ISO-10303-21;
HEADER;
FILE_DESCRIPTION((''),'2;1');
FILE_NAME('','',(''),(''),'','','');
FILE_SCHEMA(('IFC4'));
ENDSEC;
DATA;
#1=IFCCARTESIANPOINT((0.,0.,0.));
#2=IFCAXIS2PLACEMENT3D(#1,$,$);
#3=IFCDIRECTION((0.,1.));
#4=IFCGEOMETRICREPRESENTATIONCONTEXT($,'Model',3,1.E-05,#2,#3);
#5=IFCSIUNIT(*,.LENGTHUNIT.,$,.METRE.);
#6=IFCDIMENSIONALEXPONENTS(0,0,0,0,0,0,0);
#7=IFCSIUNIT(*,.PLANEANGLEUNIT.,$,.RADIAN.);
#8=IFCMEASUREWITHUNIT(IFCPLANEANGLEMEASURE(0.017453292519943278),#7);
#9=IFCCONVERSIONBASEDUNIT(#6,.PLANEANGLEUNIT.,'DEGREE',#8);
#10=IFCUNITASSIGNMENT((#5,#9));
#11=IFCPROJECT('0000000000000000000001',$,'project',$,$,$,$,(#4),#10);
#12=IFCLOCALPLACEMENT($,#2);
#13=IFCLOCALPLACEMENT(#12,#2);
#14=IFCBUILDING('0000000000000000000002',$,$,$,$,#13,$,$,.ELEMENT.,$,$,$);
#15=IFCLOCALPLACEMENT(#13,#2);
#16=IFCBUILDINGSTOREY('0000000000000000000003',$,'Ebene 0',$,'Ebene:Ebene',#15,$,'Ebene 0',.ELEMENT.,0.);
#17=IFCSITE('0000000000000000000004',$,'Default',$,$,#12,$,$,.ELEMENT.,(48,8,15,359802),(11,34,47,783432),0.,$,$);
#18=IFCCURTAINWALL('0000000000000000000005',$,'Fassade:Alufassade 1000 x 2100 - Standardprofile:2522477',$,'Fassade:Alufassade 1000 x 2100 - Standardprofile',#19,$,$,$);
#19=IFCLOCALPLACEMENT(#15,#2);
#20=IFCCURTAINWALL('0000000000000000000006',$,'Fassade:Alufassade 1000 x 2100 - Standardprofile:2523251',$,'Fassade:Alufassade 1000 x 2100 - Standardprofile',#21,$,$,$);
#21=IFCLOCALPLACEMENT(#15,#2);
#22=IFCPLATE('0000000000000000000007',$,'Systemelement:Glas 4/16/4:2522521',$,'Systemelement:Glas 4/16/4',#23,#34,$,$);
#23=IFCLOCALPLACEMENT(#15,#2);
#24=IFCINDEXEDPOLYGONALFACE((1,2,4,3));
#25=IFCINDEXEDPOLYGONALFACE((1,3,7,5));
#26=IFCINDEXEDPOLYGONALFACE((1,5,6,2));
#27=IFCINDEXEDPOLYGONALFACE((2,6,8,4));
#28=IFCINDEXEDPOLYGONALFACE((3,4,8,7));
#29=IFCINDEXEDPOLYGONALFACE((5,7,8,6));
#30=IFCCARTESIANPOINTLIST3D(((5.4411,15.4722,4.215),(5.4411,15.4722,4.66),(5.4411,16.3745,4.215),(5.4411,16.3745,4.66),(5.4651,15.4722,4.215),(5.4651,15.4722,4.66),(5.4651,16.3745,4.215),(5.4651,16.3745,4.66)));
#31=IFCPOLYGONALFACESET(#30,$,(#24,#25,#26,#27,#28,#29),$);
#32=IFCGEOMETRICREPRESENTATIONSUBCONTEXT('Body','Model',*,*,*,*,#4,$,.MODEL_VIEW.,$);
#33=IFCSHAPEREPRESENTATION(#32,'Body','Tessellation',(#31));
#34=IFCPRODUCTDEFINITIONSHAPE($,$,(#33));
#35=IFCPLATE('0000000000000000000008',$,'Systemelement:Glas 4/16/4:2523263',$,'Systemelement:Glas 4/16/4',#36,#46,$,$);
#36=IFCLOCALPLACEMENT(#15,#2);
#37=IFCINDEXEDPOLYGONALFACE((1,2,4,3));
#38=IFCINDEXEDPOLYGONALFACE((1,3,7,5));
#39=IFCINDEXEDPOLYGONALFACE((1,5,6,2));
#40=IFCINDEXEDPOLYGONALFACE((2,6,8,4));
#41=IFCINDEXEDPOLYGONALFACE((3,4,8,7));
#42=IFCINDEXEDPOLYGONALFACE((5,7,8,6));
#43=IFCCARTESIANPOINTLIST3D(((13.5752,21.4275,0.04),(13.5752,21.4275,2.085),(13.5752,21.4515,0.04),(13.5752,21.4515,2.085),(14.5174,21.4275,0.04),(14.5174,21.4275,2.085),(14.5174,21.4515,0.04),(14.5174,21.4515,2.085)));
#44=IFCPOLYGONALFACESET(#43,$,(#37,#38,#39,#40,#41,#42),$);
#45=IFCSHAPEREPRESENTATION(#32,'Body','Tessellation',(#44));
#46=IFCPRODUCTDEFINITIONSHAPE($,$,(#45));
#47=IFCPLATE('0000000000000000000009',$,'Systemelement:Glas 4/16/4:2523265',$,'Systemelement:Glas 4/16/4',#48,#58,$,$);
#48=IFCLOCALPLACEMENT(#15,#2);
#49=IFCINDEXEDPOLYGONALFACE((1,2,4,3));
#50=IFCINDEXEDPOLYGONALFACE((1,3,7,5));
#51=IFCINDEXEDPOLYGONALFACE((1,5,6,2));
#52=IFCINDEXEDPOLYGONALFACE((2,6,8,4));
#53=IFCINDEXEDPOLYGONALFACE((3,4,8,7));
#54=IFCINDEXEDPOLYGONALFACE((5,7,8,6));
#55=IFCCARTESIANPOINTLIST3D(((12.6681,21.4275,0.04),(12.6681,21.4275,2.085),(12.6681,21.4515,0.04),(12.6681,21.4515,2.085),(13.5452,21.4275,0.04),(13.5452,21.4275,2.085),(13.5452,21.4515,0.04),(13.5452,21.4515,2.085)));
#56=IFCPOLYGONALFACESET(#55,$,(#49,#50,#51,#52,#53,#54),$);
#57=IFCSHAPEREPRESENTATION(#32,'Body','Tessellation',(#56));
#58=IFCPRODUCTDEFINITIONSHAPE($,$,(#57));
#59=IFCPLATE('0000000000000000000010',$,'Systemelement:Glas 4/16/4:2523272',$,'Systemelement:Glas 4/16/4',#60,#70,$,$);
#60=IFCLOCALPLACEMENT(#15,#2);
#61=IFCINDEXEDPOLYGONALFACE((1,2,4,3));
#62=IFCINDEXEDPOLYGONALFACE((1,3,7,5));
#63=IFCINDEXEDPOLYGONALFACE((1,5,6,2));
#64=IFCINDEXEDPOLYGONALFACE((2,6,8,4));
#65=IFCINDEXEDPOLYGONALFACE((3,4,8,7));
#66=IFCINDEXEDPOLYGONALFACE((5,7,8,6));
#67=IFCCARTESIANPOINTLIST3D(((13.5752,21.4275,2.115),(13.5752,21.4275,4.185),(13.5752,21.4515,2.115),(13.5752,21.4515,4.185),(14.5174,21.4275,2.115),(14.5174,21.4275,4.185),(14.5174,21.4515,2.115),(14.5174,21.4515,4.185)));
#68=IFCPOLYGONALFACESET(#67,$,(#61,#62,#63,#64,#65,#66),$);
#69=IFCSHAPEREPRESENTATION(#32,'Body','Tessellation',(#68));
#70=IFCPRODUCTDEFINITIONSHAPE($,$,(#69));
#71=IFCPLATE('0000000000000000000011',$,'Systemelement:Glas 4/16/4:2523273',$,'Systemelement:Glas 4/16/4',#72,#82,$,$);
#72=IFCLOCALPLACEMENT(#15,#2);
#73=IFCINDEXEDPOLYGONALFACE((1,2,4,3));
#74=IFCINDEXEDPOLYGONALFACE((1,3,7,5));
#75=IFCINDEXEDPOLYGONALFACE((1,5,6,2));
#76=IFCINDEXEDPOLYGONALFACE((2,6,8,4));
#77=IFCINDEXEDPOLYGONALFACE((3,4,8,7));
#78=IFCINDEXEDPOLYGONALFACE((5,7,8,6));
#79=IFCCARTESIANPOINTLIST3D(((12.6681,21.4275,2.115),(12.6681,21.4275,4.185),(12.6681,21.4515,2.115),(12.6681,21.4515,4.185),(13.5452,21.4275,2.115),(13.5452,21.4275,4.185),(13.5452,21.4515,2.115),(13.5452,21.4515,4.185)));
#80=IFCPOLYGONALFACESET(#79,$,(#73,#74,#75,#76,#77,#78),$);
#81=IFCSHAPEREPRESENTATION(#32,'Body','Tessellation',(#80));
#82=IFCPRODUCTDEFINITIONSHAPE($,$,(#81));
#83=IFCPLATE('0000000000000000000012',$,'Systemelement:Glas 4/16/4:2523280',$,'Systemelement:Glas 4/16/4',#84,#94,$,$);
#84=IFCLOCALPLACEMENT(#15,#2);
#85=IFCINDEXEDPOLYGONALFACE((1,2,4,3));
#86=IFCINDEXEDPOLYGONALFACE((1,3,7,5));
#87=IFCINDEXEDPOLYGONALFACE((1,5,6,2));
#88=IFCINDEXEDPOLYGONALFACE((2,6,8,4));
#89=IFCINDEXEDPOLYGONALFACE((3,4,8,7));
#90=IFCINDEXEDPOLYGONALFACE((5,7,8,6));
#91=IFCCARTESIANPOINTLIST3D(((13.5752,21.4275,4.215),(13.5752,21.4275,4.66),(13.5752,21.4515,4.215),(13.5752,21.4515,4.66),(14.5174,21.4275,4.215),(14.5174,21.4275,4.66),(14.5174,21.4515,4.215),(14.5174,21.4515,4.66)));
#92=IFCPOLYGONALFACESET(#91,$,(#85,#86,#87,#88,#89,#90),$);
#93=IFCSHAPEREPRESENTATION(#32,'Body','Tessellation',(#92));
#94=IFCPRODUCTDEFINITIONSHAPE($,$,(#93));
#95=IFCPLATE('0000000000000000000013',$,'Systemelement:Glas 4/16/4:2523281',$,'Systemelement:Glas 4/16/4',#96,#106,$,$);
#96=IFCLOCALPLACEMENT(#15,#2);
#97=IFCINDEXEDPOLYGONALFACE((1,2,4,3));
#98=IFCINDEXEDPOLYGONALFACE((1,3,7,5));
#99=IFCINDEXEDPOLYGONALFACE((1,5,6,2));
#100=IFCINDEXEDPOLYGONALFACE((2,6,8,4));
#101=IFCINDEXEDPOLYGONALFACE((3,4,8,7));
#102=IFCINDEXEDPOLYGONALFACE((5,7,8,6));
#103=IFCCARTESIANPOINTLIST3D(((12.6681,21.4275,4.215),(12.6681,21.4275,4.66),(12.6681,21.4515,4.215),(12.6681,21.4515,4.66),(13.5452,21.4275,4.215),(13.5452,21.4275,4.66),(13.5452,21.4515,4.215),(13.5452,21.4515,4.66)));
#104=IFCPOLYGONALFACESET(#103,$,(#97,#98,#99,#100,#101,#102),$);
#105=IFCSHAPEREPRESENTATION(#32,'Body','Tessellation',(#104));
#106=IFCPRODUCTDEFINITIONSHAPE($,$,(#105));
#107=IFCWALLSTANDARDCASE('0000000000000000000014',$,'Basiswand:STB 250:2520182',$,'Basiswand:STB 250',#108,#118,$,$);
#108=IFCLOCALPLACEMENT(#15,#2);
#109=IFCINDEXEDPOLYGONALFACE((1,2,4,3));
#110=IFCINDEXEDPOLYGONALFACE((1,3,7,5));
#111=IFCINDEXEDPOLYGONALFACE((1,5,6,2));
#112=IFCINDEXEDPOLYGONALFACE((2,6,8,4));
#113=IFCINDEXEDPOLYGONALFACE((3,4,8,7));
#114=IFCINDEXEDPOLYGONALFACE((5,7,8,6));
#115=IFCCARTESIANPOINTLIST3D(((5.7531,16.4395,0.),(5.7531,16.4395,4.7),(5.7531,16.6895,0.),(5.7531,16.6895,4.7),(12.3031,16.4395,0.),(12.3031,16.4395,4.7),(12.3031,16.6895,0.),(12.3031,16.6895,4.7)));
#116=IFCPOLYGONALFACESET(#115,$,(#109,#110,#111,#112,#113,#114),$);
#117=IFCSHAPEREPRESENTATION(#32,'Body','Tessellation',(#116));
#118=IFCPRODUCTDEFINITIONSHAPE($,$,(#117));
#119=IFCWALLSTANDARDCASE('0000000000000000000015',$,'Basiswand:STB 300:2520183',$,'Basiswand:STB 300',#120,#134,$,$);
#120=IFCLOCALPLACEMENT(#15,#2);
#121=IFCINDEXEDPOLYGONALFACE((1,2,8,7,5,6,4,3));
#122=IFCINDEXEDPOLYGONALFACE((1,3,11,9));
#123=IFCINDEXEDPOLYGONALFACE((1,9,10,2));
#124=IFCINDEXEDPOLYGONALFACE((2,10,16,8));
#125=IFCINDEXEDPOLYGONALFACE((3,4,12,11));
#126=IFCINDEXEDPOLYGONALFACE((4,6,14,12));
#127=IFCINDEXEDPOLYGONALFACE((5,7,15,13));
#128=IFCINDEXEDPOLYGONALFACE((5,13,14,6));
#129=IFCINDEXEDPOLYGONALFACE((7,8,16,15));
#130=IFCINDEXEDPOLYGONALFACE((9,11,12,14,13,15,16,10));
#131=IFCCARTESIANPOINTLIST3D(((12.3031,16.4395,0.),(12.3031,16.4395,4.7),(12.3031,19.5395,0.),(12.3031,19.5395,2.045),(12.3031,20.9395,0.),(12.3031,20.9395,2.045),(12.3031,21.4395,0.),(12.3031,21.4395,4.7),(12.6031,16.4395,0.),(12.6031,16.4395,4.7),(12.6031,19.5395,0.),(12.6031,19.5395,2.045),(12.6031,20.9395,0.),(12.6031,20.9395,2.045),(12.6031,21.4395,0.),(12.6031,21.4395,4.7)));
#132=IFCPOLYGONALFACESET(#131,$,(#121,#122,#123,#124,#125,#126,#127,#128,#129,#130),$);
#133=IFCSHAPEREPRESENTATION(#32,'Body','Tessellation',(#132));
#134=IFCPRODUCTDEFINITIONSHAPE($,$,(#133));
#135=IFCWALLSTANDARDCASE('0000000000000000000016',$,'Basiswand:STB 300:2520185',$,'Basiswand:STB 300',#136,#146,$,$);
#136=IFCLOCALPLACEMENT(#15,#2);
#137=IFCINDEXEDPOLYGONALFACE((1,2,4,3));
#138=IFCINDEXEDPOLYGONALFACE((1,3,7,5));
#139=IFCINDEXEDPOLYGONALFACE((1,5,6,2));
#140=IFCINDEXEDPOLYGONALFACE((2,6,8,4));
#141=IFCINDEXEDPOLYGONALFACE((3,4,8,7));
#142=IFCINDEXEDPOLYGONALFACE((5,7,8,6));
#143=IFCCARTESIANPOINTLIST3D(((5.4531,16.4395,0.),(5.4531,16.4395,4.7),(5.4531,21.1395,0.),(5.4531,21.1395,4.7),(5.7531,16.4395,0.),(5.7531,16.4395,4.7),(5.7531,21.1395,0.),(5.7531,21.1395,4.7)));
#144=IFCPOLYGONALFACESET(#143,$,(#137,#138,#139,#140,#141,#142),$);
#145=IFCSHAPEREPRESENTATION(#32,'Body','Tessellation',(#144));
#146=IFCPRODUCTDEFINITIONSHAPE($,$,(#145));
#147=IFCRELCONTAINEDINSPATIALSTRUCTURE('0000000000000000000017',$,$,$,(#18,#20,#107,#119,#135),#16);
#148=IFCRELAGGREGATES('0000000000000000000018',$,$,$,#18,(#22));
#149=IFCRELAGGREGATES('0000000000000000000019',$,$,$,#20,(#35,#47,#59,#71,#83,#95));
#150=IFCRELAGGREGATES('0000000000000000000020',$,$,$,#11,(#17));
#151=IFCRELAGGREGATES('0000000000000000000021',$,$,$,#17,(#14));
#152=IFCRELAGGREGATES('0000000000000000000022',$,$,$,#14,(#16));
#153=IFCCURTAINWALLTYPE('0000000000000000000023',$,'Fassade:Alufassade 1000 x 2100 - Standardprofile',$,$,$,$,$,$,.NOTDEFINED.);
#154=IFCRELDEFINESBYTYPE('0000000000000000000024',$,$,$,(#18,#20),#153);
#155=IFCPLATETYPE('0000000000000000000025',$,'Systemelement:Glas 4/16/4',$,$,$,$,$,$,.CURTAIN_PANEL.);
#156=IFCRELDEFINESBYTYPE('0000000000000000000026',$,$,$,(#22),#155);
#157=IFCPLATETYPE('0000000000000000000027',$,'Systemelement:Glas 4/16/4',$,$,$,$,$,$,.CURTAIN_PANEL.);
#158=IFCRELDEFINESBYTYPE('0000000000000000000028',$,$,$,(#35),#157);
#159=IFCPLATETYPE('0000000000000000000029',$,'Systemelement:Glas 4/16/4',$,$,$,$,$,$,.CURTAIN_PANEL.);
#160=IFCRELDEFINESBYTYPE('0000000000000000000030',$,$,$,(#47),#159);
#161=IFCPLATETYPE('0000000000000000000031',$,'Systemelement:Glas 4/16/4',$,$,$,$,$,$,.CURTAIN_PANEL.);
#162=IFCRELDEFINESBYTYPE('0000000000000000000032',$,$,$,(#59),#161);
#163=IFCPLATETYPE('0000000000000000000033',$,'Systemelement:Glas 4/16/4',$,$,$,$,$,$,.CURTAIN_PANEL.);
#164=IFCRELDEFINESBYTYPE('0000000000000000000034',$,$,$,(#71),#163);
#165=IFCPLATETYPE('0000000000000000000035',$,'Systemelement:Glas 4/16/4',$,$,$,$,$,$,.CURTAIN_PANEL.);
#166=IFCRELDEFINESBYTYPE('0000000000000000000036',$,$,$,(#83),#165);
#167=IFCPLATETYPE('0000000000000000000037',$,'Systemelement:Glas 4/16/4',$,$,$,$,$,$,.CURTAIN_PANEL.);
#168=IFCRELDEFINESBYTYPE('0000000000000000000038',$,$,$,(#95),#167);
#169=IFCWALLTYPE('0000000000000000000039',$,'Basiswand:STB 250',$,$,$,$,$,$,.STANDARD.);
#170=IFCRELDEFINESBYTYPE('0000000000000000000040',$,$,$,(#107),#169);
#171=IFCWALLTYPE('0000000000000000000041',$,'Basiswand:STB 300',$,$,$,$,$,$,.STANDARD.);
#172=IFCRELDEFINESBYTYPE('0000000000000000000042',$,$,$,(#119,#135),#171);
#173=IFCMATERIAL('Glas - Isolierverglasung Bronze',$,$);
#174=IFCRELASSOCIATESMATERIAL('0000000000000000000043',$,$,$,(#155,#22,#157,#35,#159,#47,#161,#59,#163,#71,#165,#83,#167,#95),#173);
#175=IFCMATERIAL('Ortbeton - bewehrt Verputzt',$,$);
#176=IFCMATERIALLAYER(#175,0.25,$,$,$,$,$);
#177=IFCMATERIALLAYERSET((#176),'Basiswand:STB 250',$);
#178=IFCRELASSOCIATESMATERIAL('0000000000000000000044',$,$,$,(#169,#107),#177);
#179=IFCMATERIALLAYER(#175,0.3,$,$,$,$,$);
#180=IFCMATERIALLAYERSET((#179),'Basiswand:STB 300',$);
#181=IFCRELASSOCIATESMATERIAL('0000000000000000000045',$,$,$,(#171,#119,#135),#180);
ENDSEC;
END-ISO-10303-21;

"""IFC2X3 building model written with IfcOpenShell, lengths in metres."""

from ifc_helpers import new_model, entity, si_unit, converted_unit, direction, frame, frame_2d, origin, origin_2d_with_axis, place, context, subcontext, project, spatial, polyline, rectangle, extrude, clip, bounded_halfspace, source, transform, mapped, material, layer, layer_set, layer_usage, type_object, type_shapes, element, aggregate, save


model = new_model("IFC2X3")

# Units and contexts
model_context = context("Model", 3, precision=1e-05, world=origin(), true_north=direction((0.0, 1.0)))
body_context = subcontext(model_context, "Body", "Model", "MODEL_VIEW")
ifc_project = project(units=[si_unit("LENGTHUNIT", "METRE"), converted_unit("PLANEANGLEUNIT", "DEGREE", entity("IfcPlaneAngleMeasure", 0.017453292519943278), si_unit("PLANEANGLEUNIT", "RADIAN"), dimensions=[0, 0, 0, 0, 0, 0, 0])], contexts=[model_context])

# Site, building, storey
site_placement = place(None, origin())
site = spatial("IfcSite", under=ifc_project, at=site_placement, Name="Default", CompositionType="ELEMENT", RefLatitude=(48, 8, 15, 359802), RefLongitude=(11, 34, 47, 783432), RefElevation=0.0)
building_placement = place(site_placement, origin())
building = spatial("IfcBuilding", under=site, at=building_placement, CompositionType="ELEMENT")
storey_placement = place(building_placement, origin())
storey = spatial("IfcBuildingStorey", under=building, at=storey_placement, Name="Ebene 0", ObjectType="Ebene:Ebene", LongName="Ebene 0", CompositionType="ELEMENT", Elevation=0.0)

# Curtain wall
curtain_wall_type = type_object("IfcCurtainWallType", Name="Fassade:Alufassade 1000 x 2100 - Standardprofile", PredefinedType="NOTDEFINED")
curtain_wall_1_placement = place(storey_placement, origin())
curtain_wall_1 = element("IfcCurtainWall", 1, at=curtain_wall_1_placement, inside=storey, type_object=curtain_wall_type, Name="Fassade:Alufassade 1000 x 2100 - Standardprofile:2522477", ObjectType="Fassade:Alufassade 1000 x 2100 - Standardprofile")

# Curtain wall
curtain_wall_2_placement = place(storey_placement, origin())
curtain_wall_2 = element("IfcCurtainWall", 2, at=curtain_wall_2_placement, inside=storey, type_object=curtain_wall_type, Name="Fassade:Alufassade 1000 x 2100 - Standardprofile:2523251", ObjectType="Fassade:Alufassade 1000 x 2100 - Standardprofile")

# Plates
ifc_material_1 = material(Name="Glas - Isolierverglasung Bronze")
plate_type_1 = type_object("IfcPlateType", Name="Systemelement:Glas 4/16/4", PredefinedType="CURTAIN_PANEL", material=ifc_material_1)
shared_shape_1 = source(origin(), body_context, "Body", "SweptSolid", [
    extrude(rectangle(XDim=0.024, YDim=0.9023, at=origin_2d_with_axis()), frame((0.0, 0.0, 0.0), z_axis=(0.0, 0.0, 1.0), x_axis=(0.0, 1.0, 0.0)), (0.0, 0.0, 1.0), 0.445),
])
type_shapes(plate_type_1, [shared_shape_1])
plate_1_placement = place(curtain_wall_1_placement, frame((5.4531, 15.9233, 4.215), z_axis=(0.0, 0.0, 1.0), x_axis=(0.0, -1.0, 0.0)))
plate_1 = element("IfcPlate", 3, at=plate_1_placement, type_object=plate_type_1, material=ifc_material_1, Name="Systemelement:Glas 4/16/4:2522521", ObjectType="Systemelement:Glas 4/16/4", context=body_context, shape_type="MappedRepresentation", body=[
    mapped(shared_shape_1, transform((0.0, 0.0, 0.0), scale=1.0)),
])
aggregate(curtain_wall_1, [plate_1])
plate_type_2 = type_object("IfcPlateType", Name="Systemelement:Glas 4/16/4", PredefinedType="CURTAIN_PANEL", material=ifc_material_1)
shared_shape_2 = source(origin(), body_context, "Body", "SweptSolid", [
    extrude(rectangle(XDim=0.024, YDim=0.9421, at=origin_2d_with_axis()), frame((0.0, 0.0, 0.0), z_axis=(0.0, 0.0, 1.0), x_axis=(0.0, 1.0, 0.0)), (0.0, 0.0, 1.0), 2.045),
])
type_shapes(plate_type_2, [shared_shape_2])
plate_2_placement = place(curtain_wall_2_placement, frame((14.0463, 21.4395, 0.04), z_axis=(0.0, 0.0, 1.0), x_axis=(-1.0, 0.0, 0.0)))
plate_2 = element("IfcPlate", 4, at=plate_2_placement, type_object=plate_type_2, material=ifc_material_1, Name="Systemelement:Glas 4/16/4:2523263", ObjectType="Systemelement:Glas 4/16/4", context=body_context, shape_type="MappedRepresentation", body=[
    mapped(shared_shape_2, transform((0.0, 0.0, 0.0), scale=1.0)),
])
plate_type_3 = type_object("IfcPlateType", Name="Systemelement:Glas 4/16/4", PredefinedType="CURTAIN_PANEL", material=ifc_material_1)
shared_shape_3 = source(origin(), body_context, "Body", "SweptSolid", [
    extrude(rectangle(XDim=0.024, YDim=0.8771, at=origin_2d_with_axis()), frame((0.0, 0.0, 0.0), z_axis=(0.0, 0.0, 1.0), x_axis=(0.0, 1.0, 0.0)), (0.0, 0.0, 1.0), 2.045),
])
type_shapes(plate_type_3, [shared_shape_3])
plate_3_placement = place(curtain_wall_2_placement, frame((13.1067, 21.4395, 0.04), z_axis=(0.0, 0.0, 1.0), x_axis=(-1.0, 0.0, 0.0)))
plate_3 = element("IfcPlate", 5, at=plate_3_placement, type_object=plate_type_3, material=ifc_material_1, Name="Systemelement:Glas 4/16/4:2523265", ObjectType="Systemelement:Glas 4/16/4", context=body_context, shape_type="MappedRepresentation", body=[
    mapped(shared_shape_3, transform((0.0, 0.0, 0.0), scale=1.0)),
])
plate_type_4 = type_object("IfcPlateType", Name="Systemelement:Glas 4/16/4", PredefinedType="CURTAIN_PANEL", material=ifc_material_1)
shared_shape_4 = source(origin(), body_context, "Body", "SweptSolid", [
    extrude(rectangle(XDim=0.024, YDim=0.9421, at=origin_2d_with_axis()), frame((0.0, 0.0, 0.0), z_axis=(0.0, 0.0, 1.0), x_axis=(0.0, 1.0, 0.0)), (0.0, 0.0, 1.0), 2.07),
])
type_shapes(plate_type_4, [shared_shape_4])
plate_4_placement = place(curtain_wall_2_placement, frame((14.0463, 21.4395, 2.115), z_axis=(0.0, 0.0, 1.0), x_axis=(-1.0, 0.0, 0.0)))
plate_4 = element("IfcPlate", 6, at=plate_4_placement, type_object=plate_type_4, material=ifc_material_1, Name="Systemelement:Glas 4/16/4:2523272", ObjectType="Systemelement:Glas 4/16/4", context=body_context, shape_type="MappedRepresentation", body=[
    mapped(shared_shape_4, transform((0.0, 0.0, 0.0), scale=1.0)),
])
plate_type_5 = type_object("IfcPlateType", Name="Systemelement:Glas 4/16/4", PredefinedType="CURTAIN_PANEL", material=ifc_material_1)
shared_shape_5 = source(origin(), body_context, "Body", "SweptSolid", [
    extrude(rectangle(XDim=0.024, YDim=0.8771, at=origin_2d_with_axis()), frame((0.0, 0.0, 0.0), z_axis=(0.0, 0.0, 1.0), x_axis=(0.0, 1.0, 0.0)), (0.0, 0.0, 1.0), 2.07),
])
type_shapes(plate_type_5, [shared_shape_5])
plate_5_placement = place(curtain_wall_2_placement, frame((13.1067, 21.4395, 2.115), z_axis=(0.0, 0.0, 1.0), x_axis=(-1.0, 0.0, 0.0)))
plate_5 = element("IfcPlate", 7, at=plate_5_placement, type_object=plate_type_5, material=ifc_material_1, Name="Systemelement:Glas 4/16/4:2523273", ObjectType="Systemelement:Glas 4/16/4", context=body_context, shape_type="MappedRepresentation", body=[
    mapped(shared_shape_5, transform((0.0, 0.0, 0.0), scale=1.0)),
])
plate_type_6 = type_object("IfcPlateType", Name="Systemelement:Glas 4/16/4", PredefinedType="CURTAIN_PANEL", material=ifc_material_1)
shared_shape_6 = source(origin(), body_context, "Body", "SweptSolid", [
    extrude(rectangle(XDim=0.024, YDim=0.9421, at=origin_2d_with_axis()), frame((0.0, 0.0, 0.0), z_axis=(0.0, 0.0, 1.0), x_axis=(0.0, 1.0, 0.0)), (0.0, 0.0, 1.0), 0.445),
])
type_shapes(plate_type_6, [shared_shape_6])
plate_6_placement = place(curtain_wall_2_placement, frame((14.0463, 21.4395, 4.215), z_axis=(0.0, 0.0, 1.0), x_axis=(-1.0, 0.0, 0.0)))
plate_6 = element("IfcPlate", 8, at=plate_6_placement, type_object=plate_type_6, material=ifc_material_1, Name="Systemelement:Glas 4/16/4:2523280", ObjectType="Systemelement:Glas 4/16/4", context=body_context, shape_type="MappedRepresentation", body=[
    mapped(shared_shape_6, transform((0.0, 0.0, 0.0), scale=1.0)),
])
plate_type_7 = type_object("IfcPlateType", Name="Systemelement:Glas 4/16/4", PredefinedType="CURTAIN_PANEL", material=ifc_material_1)
shared_shape_7 = source(origin(), body_context, "Body", "SweptSolid", [
    extrude(rectangle(XDim=0.024, YDim=0.8771, at=origin_2d_with_axis()), frame((0.0, 0.0, 0.0), z_axis=(0.0, 0.0, 1.0), x_axis=(0.0, 1.0, 0.0)), (0.0, 0.0, 1.0), 0.445),
])
type_shapes(plate_type_7, [shared_shape_7])
plate_7_placement = place(curtain_wall_2_placement, frame((13.1067, 21.4395, 4.215), z_axis=(0.0, 0.0, 1.0), x_axis=(-1.0, 0.0, 0.0)))
plate_7 = element("IfcPlate", 9, at=plate_7_placement, type_object=plate_type_7, material=ifc_material_1, Name="Systemelement:Glas 4/16/4:2523281", ObjectType="Systemelement:Glas 4/16/4", context=body_context, shape_type="MappedRepresentation", body=[
    mapped(shared_shape_7, transform((0.0, 0.0, 0.0), scale=1.0)),
])
aggregate(curtain_wall_2, [plate_2, plate_3, plate_4, plate_5, plate_6, plate_7])

# Wall
ifc_material_2 = material(Name="Ortbeton - bewehrt Verputzt")
ifc_layer_1 = layer(ifc_material_2, 0.25)
ifc_layer_set_1 = layer_set([ifc_layer_1], Name="Basiswand:STB 250")
ifc_layer_usage_1 = layer_usage(ifc_layer_set_1, "AXIS2", "NEGATIVE", 0.125)
wall_type_1 = type_object("IfcWallType", Name="Basiswand:STB 250", PredefinedType="STANDARD", material=ifc_layer_set_1)
wall_1_placement = place(storey_placement, frame((12.3031, 16.5645, 0.0), z_axis=(0.0, 0.0, 1.0), x_axis=(-1.0, 0.0, 0.0)))
element("IfcWallStandardCase", 10, at=wall_1_placement, inside=storey, type_object=wall_type_1, material=ifc_layer_usage_1, Name="Basiswand:STB 250:2520182", ObjectType="Basiswand:STB 250", context=body_context, shape_type="Clipping", body=[
    clip(extrude(rectangle(XDim=6.55, YDim=0.25, at=frame_2d((3.275, 0.0), x_axis=(-1.0, 0.0))), origin(), (0.0, 0.0, 1.0), 4.7), bounded_halfspace(frame((0.0, -0.125, 4.7), z_axis=(0.0, 0.0, -1.0), x_axis=(0.0, 1.0, 0.0)), True, frame((0.0, -0.125, 4.7)), polyline([(0.0, 0.0), (6.55, 0.0), (6.55, 0.25), (3.6, 0.25), (3.3, 0.25), (0.0, 0.25), (0.0, 0.0)]))),
])

# Wall, opening
ifc_layer_2 = layer(ifc_material_2, 0.3)
ifc_layer_set_2 = layer_set([ifc_layer_2], Name="Basiswand:STB 300")
ifc_layer_usage_2 = layer_usage(ifc_layer_set_2, "AXIS2", "NEGATIVE", 0.15)
wall_type_2 = type_object("IfcWallType", Name="Basiswand:STB 300", PredefinedType="STANDARD", material=ifc_layer_set_2)
wall_2_placement = place(storey_placement, frame((12.4531, 21.4395, 0.0), z_axis=(0.0, 0.0, 1.0), x_axis=(0.0, -1.0, 0.0)))
wall_2 = element("IfcWallStandardCase", 11, at=wall_2_placement, inside=storey, type_object=wall_type_2, material=ifc_layer_usage_2, Name="Basiswand:STB 300:2520183", ObjectType="Basiswand:STB 300", context=body_context, shape_type="Clipping", body=[
    clip(extrude(rectangle(XDim=5.0, YDim=0.3, at=frame_2d((2.5, 0.0), x_axis=(-1.0, 0.0))), origin(), (0.0, 0.0, 1.0), 4.7), bounded_halfspace(frame((0.0, -0.15, 4.7), z_axis=(0.0, 0.0, -1.0), x_axis=(1.0, 0.0, 0.0)), True, frame((0.0, -0.15, 4.7)), polyline([(0.0, 0.0), (0.3, 0.0), (4.75, 0.0), (5.0, 0.0), (5.0, 0.3), (1.15, 0.3), (0.85, 0.3), (0.0, 0.3), (0.0, 0.0)]))),
])
opening_1_placement = place(wall_2_placement, frame((1.9, 0.15, -0.18)))
element("IfcOpeningElement", 12, at=opening_1_placement, cuts=wall_2, ObjectType="Opening", context=body_context, shape_type="SweptSolid", body=[
    extrude(rectangle(XDim=2.225, YDim=1.4, at=frame_2d((1.1125, 0.7), x_axis=(-1.0, 0.0))), frame((0.0, 0.0, 0.0), z_axis=(0.0, -1.0, 0.0), x_axis=(0.0, 0.0, 1.0)), (0.0, 0.0, 1.0), 0.3),
])

# Wall
ifc_layer_usage_3 = layer_usage(ifc_layer_set_2, "AXIS2", "NEGATIVE", 0.15)
wall_3_placement = place(storey_placement, frame((5.6031, 16.4395, 0.0), z_axis=(0.0, 0.0, 1.0), x_axis=(0.0, 1.0, 0.0)))
element("IfcWallStandardCase", 13, at=wall_3_placement, inside=storey, type_object=wall_type_2, material=ifc_layer_usage_3, Name="Basiswand:STB 300:2520185", ObjectType="Basiswand:STB 300", context=body_context, shape_type="Clipping", body=[
    clip(extrude(rectangle(XDim=4.7, YDim=0.3, at=frame_2d((2.35, 0.0), x_axis=(-1.0, 0.0))), origin(), (0.0, 0.0, 1.0), 4.7), bounded_halfspace(frame((0.0, -0.15, 4.7), z_axis=(0.0, 0.0, -1.0), x_axis=(-1.0, 0.0, 0.0)), True, frame((0.0, -0.15, 4.7)), polyline([(0.0, 0.0), (0.25, 0.0), (4.7, 0.0), (4.7, 0.3), (0.0, 0.3), (0.0, 0.0)]))),
])

save(model, "model.ifc")
